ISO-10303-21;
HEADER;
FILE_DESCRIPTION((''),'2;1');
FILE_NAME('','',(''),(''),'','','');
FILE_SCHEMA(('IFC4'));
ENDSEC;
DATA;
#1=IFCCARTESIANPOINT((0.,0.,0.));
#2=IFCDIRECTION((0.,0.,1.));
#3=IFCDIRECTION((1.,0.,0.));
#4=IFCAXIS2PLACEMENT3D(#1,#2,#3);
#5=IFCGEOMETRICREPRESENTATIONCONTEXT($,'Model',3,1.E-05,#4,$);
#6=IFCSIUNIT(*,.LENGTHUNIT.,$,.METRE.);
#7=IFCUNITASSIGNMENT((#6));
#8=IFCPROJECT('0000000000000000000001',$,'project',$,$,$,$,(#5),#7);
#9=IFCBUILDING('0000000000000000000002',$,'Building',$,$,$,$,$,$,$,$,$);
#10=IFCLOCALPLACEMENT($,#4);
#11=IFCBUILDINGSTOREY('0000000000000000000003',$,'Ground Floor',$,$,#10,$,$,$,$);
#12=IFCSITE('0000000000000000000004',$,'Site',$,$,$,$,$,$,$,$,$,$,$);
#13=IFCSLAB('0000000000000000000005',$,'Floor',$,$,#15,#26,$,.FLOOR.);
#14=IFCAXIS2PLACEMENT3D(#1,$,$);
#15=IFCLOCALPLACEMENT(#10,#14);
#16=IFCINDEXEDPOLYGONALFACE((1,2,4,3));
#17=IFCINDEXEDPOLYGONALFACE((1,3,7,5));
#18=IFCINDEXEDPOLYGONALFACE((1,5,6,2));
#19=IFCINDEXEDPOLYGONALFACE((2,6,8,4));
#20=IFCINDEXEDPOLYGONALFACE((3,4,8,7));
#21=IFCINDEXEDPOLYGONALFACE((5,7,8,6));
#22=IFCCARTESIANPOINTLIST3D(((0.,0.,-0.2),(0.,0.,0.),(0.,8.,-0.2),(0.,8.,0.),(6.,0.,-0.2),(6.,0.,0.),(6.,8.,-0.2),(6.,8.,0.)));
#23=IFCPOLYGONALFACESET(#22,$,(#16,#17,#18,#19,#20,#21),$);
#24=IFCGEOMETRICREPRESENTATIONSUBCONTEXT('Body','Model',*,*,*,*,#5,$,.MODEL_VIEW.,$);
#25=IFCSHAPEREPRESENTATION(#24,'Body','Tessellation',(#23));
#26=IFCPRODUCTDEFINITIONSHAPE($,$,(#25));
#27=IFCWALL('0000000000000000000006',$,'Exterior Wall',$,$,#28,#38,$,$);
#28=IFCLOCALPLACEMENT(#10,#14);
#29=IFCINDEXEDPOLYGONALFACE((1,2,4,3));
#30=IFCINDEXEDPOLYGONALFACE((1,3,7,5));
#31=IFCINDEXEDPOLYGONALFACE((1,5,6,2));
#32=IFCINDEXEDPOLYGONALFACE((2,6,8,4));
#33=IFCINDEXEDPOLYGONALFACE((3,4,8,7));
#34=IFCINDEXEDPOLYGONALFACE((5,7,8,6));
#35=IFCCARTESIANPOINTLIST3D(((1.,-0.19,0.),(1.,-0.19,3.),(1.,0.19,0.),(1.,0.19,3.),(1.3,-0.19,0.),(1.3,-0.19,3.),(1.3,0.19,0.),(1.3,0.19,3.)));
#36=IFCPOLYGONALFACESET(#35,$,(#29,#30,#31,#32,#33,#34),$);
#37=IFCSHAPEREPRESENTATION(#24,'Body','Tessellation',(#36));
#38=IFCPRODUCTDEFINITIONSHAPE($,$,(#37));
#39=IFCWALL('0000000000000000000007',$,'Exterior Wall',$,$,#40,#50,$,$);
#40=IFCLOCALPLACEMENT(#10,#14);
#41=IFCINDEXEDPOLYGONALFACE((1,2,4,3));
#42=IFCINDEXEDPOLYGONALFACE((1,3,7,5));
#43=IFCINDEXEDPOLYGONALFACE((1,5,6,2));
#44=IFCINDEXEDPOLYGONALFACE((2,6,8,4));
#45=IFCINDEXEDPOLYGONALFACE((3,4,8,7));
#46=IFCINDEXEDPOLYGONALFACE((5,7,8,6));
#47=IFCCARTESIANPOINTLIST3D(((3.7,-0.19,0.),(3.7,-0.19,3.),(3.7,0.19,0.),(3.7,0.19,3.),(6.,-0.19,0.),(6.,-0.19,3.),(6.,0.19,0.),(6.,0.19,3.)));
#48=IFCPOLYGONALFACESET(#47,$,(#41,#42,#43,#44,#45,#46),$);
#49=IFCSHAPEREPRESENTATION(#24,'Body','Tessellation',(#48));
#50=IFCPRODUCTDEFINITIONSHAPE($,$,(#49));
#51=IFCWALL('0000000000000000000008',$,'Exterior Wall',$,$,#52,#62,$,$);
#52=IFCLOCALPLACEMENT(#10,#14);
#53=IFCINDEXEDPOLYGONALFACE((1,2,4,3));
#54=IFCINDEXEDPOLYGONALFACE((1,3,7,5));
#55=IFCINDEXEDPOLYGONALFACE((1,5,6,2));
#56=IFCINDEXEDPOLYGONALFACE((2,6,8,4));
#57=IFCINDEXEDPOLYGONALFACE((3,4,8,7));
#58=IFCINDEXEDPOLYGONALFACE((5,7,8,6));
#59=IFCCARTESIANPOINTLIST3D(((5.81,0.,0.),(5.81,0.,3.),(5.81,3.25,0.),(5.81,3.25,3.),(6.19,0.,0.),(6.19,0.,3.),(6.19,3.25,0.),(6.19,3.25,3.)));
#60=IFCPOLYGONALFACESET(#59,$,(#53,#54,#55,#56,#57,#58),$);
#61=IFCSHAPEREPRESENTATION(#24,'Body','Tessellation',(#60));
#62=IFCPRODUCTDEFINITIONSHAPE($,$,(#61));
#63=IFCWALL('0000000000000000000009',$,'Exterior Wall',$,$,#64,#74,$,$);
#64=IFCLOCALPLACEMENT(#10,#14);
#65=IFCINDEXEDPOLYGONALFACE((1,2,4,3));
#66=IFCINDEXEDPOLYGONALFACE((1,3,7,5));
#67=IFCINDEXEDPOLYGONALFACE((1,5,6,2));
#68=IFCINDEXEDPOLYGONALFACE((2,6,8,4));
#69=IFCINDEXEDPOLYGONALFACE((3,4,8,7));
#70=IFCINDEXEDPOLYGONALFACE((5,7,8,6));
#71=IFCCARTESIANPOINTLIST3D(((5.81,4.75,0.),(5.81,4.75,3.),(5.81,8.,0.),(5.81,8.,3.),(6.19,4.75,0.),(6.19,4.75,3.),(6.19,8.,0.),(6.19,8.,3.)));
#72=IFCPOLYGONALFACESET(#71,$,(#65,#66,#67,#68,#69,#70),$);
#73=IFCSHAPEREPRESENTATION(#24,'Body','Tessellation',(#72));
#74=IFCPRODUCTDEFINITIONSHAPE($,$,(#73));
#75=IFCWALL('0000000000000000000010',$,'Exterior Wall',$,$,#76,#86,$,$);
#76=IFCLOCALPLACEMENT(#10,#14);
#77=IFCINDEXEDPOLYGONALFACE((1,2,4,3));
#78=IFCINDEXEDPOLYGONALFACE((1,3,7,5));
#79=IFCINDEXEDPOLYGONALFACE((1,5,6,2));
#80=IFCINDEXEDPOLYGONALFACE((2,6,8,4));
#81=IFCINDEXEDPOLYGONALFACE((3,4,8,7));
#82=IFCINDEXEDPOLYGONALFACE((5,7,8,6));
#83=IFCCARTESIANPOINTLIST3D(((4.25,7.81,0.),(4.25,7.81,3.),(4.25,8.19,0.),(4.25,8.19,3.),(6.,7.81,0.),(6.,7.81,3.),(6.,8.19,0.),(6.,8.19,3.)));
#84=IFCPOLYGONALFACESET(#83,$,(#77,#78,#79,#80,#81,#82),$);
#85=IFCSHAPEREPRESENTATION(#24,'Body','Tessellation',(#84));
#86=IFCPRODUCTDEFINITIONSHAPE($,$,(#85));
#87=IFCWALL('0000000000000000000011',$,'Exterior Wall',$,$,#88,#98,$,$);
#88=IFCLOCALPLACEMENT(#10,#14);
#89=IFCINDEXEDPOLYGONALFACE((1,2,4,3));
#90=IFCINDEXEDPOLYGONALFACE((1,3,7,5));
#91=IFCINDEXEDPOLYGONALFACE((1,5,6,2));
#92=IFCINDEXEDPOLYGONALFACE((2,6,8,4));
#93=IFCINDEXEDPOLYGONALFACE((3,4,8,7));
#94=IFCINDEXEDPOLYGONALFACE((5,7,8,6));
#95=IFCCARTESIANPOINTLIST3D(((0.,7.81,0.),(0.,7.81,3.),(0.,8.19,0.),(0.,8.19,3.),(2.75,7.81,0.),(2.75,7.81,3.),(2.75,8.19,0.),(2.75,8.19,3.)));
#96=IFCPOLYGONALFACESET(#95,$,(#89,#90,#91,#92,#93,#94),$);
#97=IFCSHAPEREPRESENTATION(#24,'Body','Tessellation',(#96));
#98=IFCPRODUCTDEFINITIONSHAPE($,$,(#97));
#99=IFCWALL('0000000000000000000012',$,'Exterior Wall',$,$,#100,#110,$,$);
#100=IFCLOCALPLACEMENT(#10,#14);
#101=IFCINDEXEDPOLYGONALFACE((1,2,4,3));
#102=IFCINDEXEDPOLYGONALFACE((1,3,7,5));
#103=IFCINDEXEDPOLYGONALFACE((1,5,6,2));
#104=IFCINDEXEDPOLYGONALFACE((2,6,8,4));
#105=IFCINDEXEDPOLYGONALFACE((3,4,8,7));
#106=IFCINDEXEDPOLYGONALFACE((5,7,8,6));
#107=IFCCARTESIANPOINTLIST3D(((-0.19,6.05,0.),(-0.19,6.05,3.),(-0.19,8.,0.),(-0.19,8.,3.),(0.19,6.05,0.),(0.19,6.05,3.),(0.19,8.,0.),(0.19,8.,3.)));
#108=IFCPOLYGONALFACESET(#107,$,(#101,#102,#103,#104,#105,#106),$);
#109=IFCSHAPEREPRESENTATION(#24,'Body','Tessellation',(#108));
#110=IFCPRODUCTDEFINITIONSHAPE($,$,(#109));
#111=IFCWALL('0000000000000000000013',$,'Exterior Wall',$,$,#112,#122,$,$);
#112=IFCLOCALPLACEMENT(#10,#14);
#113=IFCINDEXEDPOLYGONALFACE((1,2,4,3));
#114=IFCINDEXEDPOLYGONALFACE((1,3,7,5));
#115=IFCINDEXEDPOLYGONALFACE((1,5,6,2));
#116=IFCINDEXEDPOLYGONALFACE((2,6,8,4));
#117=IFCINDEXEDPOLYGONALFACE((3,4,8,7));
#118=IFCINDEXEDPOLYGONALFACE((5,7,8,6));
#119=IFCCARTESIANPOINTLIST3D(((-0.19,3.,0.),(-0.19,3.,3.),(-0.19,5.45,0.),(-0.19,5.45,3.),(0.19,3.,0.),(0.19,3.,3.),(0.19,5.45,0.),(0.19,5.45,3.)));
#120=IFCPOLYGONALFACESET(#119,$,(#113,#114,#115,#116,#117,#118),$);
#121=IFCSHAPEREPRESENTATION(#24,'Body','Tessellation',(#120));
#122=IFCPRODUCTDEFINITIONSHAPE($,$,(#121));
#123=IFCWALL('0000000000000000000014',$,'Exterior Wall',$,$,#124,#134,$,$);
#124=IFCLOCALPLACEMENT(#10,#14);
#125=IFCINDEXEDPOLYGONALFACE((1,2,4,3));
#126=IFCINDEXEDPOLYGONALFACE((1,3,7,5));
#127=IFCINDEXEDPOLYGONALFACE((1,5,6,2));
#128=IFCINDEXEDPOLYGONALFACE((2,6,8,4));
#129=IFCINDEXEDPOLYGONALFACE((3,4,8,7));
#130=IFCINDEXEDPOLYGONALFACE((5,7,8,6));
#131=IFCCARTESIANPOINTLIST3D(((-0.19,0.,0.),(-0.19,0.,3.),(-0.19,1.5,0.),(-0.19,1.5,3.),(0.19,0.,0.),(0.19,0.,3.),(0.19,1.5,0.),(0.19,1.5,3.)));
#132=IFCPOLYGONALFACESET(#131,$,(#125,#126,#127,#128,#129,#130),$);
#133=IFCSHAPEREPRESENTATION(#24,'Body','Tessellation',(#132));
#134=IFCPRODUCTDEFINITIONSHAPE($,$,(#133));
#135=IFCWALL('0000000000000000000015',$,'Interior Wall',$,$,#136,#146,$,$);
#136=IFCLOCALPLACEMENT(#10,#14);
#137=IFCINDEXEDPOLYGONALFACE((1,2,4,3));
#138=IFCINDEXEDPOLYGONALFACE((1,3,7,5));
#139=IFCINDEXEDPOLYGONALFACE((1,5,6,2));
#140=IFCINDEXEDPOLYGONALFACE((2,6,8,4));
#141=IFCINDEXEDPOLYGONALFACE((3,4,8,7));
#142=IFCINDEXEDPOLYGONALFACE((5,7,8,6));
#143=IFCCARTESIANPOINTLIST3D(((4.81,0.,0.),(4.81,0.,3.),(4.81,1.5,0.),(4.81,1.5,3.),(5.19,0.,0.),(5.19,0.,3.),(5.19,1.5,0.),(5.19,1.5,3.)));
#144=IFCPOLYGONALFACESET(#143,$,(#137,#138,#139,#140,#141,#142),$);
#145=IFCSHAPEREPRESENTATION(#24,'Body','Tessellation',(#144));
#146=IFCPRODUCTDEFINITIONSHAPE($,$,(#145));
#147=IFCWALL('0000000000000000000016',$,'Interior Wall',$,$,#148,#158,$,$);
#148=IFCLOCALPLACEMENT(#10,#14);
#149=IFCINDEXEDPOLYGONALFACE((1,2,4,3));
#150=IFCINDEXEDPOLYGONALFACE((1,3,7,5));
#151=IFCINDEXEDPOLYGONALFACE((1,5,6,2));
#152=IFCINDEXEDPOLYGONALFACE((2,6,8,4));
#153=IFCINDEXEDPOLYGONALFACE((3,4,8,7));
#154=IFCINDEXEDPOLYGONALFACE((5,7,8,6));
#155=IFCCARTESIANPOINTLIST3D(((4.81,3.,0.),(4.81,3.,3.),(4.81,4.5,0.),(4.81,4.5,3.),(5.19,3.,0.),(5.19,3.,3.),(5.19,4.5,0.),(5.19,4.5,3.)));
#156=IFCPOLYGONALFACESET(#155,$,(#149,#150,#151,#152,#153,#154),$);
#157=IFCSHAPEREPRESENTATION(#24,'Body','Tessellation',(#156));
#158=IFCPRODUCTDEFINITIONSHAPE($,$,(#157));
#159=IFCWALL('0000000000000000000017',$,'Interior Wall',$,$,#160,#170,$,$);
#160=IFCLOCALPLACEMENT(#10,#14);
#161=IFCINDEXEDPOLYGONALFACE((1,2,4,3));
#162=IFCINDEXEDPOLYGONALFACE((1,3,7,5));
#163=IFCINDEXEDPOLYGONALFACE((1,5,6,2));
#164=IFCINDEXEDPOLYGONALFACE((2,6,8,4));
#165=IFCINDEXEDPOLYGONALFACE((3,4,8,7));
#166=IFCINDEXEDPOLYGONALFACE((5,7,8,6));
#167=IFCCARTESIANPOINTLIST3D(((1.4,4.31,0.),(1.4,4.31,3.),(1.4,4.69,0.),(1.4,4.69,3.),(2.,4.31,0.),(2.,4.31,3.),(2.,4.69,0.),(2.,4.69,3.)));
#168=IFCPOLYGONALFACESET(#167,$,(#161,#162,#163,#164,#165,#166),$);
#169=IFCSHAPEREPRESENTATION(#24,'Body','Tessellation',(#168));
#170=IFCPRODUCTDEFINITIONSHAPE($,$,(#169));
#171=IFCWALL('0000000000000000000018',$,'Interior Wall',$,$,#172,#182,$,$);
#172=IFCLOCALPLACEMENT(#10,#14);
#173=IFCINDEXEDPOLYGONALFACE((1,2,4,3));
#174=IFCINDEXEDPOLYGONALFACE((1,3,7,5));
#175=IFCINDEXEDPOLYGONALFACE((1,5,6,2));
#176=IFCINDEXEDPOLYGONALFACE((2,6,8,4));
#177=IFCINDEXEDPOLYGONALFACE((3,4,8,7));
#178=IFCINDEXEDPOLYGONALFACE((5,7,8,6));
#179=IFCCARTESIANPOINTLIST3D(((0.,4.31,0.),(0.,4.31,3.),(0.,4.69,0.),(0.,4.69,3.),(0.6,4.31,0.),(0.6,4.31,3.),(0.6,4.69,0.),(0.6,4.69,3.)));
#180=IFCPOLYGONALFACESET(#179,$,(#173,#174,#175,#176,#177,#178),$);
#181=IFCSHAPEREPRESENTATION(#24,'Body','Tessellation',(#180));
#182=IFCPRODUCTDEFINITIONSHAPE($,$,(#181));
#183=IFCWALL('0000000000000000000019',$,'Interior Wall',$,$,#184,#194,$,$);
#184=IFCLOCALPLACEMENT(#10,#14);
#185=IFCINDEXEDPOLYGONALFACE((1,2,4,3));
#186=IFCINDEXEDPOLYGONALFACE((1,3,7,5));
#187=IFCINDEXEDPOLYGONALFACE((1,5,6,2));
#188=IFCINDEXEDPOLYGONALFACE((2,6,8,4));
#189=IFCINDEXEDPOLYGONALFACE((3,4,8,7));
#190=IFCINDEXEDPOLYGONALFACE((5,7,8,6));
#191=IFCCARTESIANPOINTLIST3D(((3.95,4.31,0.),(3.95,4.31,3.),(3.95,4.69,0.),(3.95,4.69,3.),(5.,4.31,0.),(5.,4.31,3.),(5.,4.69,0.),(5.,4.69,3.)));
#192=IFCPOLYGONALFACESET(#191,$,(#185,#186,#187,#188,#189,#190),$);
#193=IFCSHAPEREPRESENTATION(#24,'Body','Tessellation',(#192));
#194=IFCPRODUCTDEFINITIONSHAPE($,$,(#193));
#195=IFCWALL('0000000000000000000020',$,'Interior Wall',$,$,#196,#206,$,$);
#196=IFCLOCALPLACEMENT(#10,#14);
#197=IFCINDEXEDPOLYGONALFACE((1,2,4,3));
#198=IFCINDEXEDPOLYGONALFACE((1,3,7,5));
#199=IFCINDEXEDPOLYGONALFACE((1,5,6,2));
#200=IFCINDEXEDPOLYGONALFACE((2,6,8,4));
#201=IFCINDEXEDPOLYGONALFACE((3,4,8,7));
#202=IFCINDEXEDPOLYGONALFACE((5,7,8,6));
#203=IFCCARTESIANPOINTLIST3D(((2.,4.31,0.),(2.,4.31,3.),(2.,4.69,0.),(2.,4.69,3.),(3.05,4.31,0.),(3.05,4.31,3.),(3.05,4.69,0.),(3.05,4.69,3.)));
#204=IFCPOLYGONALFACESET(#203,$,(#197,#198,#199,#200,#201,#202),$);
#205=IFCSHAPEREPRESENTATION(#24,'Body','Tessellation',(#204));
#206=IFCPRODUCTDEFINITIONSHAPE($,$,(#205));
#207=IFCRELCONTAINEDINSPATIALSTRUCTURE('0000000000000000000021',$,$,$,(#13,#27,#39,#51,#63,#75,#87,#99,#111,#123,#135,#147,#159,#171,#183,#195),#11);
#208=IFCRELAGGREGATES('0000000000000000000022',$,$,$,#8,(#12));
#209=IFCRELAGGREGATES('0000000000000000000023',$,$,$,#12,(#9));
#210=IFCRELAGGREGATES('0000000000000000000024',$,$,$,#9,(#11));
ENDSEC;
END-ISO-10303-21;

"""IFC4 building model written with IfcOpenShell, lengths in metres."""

from ifc_helpers import new_model, si_unit, frame, origin_with_axes, place, context, subcontext, project, spatial, indexed_curve, outline, extrude, element, save


model = new_model("IFC4")

# Units and contexts
model_context = context("Model", 3, precision=1e-05, world=origin_with_axes())
body_context = subcontext(model_context, "Body", "Model", "MODEL_VIEW")
ifc_project = project(units=[si_unit("LENGTHUNIT", "METRE")], contexts=[model_context])

# Site, building, storey
site = spatial("IfcSite", under=ifc_project, Name="Site")
building = spatial("IfcBuilding", under=site, Name="Building")
storey_placement = place(None, origin_with_axes())
storey = spatial("IfcBuildingStorey", under=building, at=storey_placement, Name="Ground Floor")

# Slab
slab_placement = place(storey_placement, frame((0.0, 0.0, -0.2), z_axis=(0.0, 0.0, 1.0), x_axis=(1.0, 0.0, 0.0)))
element("IfcSlab", 1, at=slab_placement, inside=storey, Name="Floor", PredefinedType="FLOOR", context=body_context, shape_type="SweptSolid", body=[
    extrude(outline(indexed_curve([(0.0, 0.0), (6.0, 0.0), (6.0, 8.0), (0.0, 8.0)])), None, (0.0, 0.0, 1.0), 0.2),
])

# Walls
wall_1_placement = place(storey_placement, frame((1.0, 0.0, 0.0), z_axis=(0.0, 0.0, 1.0), x_axis=(1.0, 0.0, 0.0)))
element("IfcWall", 2, at=wall_1_placement, inside=storey, Name="Exterior Wall", context=body_context, shape_type="SweptSolid", body=[
    extrude(outline(indexed_curve([(0.0, 0.0), (0.0, 0.38), (0.3, 0.38), (0.3, 0.0), (0.0, 0.0)], self_intersect=False)), frame((0.0, -0.19, 0.0), z_axis=(0.0, 0.0, 1.0), x_axis=(1.0, 0.0, 0.0)), (0.0, 0.0, 1.0), 3.0),
])
wall_2_placement = place(storey_placement, frame((3.7, 0.0, 0.0), z_axis=(0.0, 0.0, 1.0), x_axis=(1.0, 0.0, 0.0)))
element("IfcWall", 3, at=wall_2_placement, inside=storey, Name="Exterior Wall", context=body_context, shape_type="SweptSolid", body=[
    extrude(outline(indexed_curve([(0.0, 0.0), (0.0, 0.38), (2.3, 0.38), (2.3, 0.0), (0.0, 0.0)], self_intersect=False)), frame((0.0, -0.19, 0.0), z_axis=(0.0, 0.0, 1.0), x_axis=(1.0, 0.0, 0.0)), (0.0, 0.0, 1.0), 3.0),
])
for number, where, z_axis, x_axis, name in (
    (4, (6.0, 0.0, 0.0), (0.0, 0.0, 1.0), (0.0, 1.0, 0.0), "Exterior Wall"),
    (5, (6.0, 4.75, 0.0), (0.0, 0.0, 1.0), (0.0, 1.0, 0.0), "Exterior Wall"),
):
    element("IfcWall", number, at=place(storey_placement, frame(where, z_axis=z_axis, x_axis=x_axis)), inside=storey, Name=name, context=body_context, shape_type="SweptSolid", body=[
        extrude(outline(indexed_curve([(0.0, 0.0), (0.0, 0.38), (3.25, 0.38), (3.25, 0.0), (0.0, 0.0)], self_intersect=False)), frame((0.0, -0.19, 0.0), z_axis=(0.0, 0.0, 1.0), x_axis=(1.0, 0.0, 0.0)), (0.0, 0.0, 1.0), 3.0),
    ])
wall_3_placement = place(storey_placement, frame((6.0, 8.0, 0.0), z_axis=(0.0, 0.0, 1.0), x_axis=(-1.0, 0.0, 0.0)))
element("IfcWall", 6, at=wall_3_placement, inside=storey, Name="Exterior Wall", context=body_context, shape_type="SweptSolid", body=[
    extrude(outline(indexed_curve([(0.0, 0.0), (0.0, 0.38), (1.75, 0.38), (1.75, 0.0), (0.0, 0.0)], self_intersect=False)), frame((0.0, -0.19, 0.0), z_axis=(0.0, 0.0, 1.0), x_axis=(1.0, 0.0, 0.0)), (0.0, 0.0, 1.0), 3.0),
])
wall_4_placement = place(storey_placement, frame((2.75, 8.0, 0.0), z_axis=(0.0, 0.0, 1.0), x_axis=(-1.0, 0.0, 0.0)))
element("IfcWall", 7, at=wall_4_placement, inside=storey, Name="Exterior Wall", context=body_context, shape_type="SweptSolid", body=[
    extrude(outline(indexed_curve([(0.0, 0.0), (0.0, 0.38), (2.75, 0.38), (2.75, 0.0), (0.0, 0.0)], self_intersect=False)), frame((0.0, -0.19, 0.0), z_axis=(0.0, 0.0, 1.0), x_axis=(1.0, 0.0, 0.0)), (0.0, 0.0, 1.0), 3.0),
])
wall_5_placement = place(storey_placement, frame((0.0, 8.0, 0.0), z_axis=(0.0, 0.0, 1.0), x_axis=(0.0, -1.0, 0.0)))
element("IfcWall", 8, at=wall_5_placement, inside=storey, Name="Exterior Wall", context=body_context, shape_type="SweptSolid", body=[
    extrude(outline(indexed_curve([(0.0, 0.0), (0.0, 0.38), (1.95, 0.38), (1.95, 0.0), (0.0, 0.0)], self_intersect=False)), frame((0.0, -0.19, 0.0), z_axis=(0.0, 0.0, 1.0), x_axis=(1.0, 0.0, 0.0)), (0.0, 0.0, 1.0), 3.0),
])
wall_6_placement = place(storey_placement, frame((0.0, 5.45, 0.0), z_axis=(0.0, 0.0, 1.0), x_axis=(0.0, -1.0, 0.0)))
element("IfcWall", 9, at=wall_6_placement, inside=storey, Name="Exterior Wall", context=body_context, shape_type="SweptSolid", body=[
    extrude(outline(indexed_curve([(0.0, 0.0), (0.0, 0.38), (2.45, 0.38), (2.45, 0.0), (0.0, 0.0)], self_intersect=False)), frame((0.0, -0.19, 0.0), z_axis=(0.0, 0.0, 1.0), x_axis=(1.0, 0.0, 0.0)), (0.0, 0.0, 1.0), 3.0),
])
for number, where, z_axis, x_axis, name in (
    (10, (0.0, 1.5, 0.0), (0.0, 0.0, 1.0), (0.0, -1.0, 0.0), "Exterior Wall"),
    (11, (5.0, 0.0, 0.0), (0.0, 0.0, 1.0), (0.0, 1.0, 0.0), "Interior Wall"),
    (12, (5.0, 3.0, 0.0), (0.0, 0.0, 1.0), (0.0, 1.0, 0.0), "Interior Wall"),
):
    element("IfcWall", number, at=place(storey_placement, frame(where, z_axis=z_axis, x_axis=x_axis)), inside=storey, Name=name, context=body_context, shape_type="SweptSolid", body=[
        extrude(outline(indexed_curve([(0.0, 0.0), (0.0, 0.38), (1.5, 0.38), (1.5, 0.0), (0.0, 0.0)], self_intersect=False)), frame((0.0, -0.19, 0.0), z_axis=(0.0, 0.0, 1.0), x_axis=(1.0, 0.0, 0.0)), (0.0, 0.0, 1.0), 3.0),
    ])
for number, where, z_axis, x_axis, name in (
    (13, (2.0, 4.5, 0.0), (0.0, 0.0, 1.0), (-1.0, 0.0, 0.0), "Interior Wall"),
    (14, (0.6, 4.5, 0.0), (0.0, 0.0, 1.0), (-1.0, 0.0, 0.0), "Interior Wall"),
):
    element("IfcWall", number, at=place(storey_placement, frame(where, z_axis=z_axis, x_axis=x_axis)), inside=storey, Name=name, context=body_context, shape_type="SweptSolid", body=[
        extrude(outline(indexed_curve([(0.0, 0.0), (0.0, 0.38), (0.6, 0.38), (0.6, 0.0), (0.0, 0.0)], self_intersect=False)), frame((0.0, -0.19, 0.0), z_axis=(0.0, 0.0, 1.0), x_axis=(1.0, 0.0, 0.0)), (0.0, 0.0, 1.0), 3.0),
    ])
for number, where, z_axis, x_axis, name in (
    (15, (5.0, 4.5, 0.0), (0.0, 0.0, 1.0), (-1.0, 0.0, 0.0), "Interior Wall"),
    (16, (3.05, 4.5, 0.0), (0.0, 0.0, 1.0), (-1.0, 0.0, 0.0), "Interior Wall"),
):
    element("IfcWall", number, at=place(storey_placement, frame(where, z_axis=z_axis, x_axis=x_axis)), inside=storey, Name=name, context=body_context, shape_type="SweptSolid", body=[
        extrude(outline(indexed_curve([(0.0, 0.0), (0.0, 0.38), (1.05, 0.38), (1.05, 0.0), (0.0, 0.0)], self_intersect=False)), frame((0.0, -0.19, 0.0), z_axis=(0.0, 0.0, 1.0), x_axis=(1.0, 0.0, 0.0)), (0.0, 0.0, 1.0), 3.0),
    ])

save(model, "model.ifc")
